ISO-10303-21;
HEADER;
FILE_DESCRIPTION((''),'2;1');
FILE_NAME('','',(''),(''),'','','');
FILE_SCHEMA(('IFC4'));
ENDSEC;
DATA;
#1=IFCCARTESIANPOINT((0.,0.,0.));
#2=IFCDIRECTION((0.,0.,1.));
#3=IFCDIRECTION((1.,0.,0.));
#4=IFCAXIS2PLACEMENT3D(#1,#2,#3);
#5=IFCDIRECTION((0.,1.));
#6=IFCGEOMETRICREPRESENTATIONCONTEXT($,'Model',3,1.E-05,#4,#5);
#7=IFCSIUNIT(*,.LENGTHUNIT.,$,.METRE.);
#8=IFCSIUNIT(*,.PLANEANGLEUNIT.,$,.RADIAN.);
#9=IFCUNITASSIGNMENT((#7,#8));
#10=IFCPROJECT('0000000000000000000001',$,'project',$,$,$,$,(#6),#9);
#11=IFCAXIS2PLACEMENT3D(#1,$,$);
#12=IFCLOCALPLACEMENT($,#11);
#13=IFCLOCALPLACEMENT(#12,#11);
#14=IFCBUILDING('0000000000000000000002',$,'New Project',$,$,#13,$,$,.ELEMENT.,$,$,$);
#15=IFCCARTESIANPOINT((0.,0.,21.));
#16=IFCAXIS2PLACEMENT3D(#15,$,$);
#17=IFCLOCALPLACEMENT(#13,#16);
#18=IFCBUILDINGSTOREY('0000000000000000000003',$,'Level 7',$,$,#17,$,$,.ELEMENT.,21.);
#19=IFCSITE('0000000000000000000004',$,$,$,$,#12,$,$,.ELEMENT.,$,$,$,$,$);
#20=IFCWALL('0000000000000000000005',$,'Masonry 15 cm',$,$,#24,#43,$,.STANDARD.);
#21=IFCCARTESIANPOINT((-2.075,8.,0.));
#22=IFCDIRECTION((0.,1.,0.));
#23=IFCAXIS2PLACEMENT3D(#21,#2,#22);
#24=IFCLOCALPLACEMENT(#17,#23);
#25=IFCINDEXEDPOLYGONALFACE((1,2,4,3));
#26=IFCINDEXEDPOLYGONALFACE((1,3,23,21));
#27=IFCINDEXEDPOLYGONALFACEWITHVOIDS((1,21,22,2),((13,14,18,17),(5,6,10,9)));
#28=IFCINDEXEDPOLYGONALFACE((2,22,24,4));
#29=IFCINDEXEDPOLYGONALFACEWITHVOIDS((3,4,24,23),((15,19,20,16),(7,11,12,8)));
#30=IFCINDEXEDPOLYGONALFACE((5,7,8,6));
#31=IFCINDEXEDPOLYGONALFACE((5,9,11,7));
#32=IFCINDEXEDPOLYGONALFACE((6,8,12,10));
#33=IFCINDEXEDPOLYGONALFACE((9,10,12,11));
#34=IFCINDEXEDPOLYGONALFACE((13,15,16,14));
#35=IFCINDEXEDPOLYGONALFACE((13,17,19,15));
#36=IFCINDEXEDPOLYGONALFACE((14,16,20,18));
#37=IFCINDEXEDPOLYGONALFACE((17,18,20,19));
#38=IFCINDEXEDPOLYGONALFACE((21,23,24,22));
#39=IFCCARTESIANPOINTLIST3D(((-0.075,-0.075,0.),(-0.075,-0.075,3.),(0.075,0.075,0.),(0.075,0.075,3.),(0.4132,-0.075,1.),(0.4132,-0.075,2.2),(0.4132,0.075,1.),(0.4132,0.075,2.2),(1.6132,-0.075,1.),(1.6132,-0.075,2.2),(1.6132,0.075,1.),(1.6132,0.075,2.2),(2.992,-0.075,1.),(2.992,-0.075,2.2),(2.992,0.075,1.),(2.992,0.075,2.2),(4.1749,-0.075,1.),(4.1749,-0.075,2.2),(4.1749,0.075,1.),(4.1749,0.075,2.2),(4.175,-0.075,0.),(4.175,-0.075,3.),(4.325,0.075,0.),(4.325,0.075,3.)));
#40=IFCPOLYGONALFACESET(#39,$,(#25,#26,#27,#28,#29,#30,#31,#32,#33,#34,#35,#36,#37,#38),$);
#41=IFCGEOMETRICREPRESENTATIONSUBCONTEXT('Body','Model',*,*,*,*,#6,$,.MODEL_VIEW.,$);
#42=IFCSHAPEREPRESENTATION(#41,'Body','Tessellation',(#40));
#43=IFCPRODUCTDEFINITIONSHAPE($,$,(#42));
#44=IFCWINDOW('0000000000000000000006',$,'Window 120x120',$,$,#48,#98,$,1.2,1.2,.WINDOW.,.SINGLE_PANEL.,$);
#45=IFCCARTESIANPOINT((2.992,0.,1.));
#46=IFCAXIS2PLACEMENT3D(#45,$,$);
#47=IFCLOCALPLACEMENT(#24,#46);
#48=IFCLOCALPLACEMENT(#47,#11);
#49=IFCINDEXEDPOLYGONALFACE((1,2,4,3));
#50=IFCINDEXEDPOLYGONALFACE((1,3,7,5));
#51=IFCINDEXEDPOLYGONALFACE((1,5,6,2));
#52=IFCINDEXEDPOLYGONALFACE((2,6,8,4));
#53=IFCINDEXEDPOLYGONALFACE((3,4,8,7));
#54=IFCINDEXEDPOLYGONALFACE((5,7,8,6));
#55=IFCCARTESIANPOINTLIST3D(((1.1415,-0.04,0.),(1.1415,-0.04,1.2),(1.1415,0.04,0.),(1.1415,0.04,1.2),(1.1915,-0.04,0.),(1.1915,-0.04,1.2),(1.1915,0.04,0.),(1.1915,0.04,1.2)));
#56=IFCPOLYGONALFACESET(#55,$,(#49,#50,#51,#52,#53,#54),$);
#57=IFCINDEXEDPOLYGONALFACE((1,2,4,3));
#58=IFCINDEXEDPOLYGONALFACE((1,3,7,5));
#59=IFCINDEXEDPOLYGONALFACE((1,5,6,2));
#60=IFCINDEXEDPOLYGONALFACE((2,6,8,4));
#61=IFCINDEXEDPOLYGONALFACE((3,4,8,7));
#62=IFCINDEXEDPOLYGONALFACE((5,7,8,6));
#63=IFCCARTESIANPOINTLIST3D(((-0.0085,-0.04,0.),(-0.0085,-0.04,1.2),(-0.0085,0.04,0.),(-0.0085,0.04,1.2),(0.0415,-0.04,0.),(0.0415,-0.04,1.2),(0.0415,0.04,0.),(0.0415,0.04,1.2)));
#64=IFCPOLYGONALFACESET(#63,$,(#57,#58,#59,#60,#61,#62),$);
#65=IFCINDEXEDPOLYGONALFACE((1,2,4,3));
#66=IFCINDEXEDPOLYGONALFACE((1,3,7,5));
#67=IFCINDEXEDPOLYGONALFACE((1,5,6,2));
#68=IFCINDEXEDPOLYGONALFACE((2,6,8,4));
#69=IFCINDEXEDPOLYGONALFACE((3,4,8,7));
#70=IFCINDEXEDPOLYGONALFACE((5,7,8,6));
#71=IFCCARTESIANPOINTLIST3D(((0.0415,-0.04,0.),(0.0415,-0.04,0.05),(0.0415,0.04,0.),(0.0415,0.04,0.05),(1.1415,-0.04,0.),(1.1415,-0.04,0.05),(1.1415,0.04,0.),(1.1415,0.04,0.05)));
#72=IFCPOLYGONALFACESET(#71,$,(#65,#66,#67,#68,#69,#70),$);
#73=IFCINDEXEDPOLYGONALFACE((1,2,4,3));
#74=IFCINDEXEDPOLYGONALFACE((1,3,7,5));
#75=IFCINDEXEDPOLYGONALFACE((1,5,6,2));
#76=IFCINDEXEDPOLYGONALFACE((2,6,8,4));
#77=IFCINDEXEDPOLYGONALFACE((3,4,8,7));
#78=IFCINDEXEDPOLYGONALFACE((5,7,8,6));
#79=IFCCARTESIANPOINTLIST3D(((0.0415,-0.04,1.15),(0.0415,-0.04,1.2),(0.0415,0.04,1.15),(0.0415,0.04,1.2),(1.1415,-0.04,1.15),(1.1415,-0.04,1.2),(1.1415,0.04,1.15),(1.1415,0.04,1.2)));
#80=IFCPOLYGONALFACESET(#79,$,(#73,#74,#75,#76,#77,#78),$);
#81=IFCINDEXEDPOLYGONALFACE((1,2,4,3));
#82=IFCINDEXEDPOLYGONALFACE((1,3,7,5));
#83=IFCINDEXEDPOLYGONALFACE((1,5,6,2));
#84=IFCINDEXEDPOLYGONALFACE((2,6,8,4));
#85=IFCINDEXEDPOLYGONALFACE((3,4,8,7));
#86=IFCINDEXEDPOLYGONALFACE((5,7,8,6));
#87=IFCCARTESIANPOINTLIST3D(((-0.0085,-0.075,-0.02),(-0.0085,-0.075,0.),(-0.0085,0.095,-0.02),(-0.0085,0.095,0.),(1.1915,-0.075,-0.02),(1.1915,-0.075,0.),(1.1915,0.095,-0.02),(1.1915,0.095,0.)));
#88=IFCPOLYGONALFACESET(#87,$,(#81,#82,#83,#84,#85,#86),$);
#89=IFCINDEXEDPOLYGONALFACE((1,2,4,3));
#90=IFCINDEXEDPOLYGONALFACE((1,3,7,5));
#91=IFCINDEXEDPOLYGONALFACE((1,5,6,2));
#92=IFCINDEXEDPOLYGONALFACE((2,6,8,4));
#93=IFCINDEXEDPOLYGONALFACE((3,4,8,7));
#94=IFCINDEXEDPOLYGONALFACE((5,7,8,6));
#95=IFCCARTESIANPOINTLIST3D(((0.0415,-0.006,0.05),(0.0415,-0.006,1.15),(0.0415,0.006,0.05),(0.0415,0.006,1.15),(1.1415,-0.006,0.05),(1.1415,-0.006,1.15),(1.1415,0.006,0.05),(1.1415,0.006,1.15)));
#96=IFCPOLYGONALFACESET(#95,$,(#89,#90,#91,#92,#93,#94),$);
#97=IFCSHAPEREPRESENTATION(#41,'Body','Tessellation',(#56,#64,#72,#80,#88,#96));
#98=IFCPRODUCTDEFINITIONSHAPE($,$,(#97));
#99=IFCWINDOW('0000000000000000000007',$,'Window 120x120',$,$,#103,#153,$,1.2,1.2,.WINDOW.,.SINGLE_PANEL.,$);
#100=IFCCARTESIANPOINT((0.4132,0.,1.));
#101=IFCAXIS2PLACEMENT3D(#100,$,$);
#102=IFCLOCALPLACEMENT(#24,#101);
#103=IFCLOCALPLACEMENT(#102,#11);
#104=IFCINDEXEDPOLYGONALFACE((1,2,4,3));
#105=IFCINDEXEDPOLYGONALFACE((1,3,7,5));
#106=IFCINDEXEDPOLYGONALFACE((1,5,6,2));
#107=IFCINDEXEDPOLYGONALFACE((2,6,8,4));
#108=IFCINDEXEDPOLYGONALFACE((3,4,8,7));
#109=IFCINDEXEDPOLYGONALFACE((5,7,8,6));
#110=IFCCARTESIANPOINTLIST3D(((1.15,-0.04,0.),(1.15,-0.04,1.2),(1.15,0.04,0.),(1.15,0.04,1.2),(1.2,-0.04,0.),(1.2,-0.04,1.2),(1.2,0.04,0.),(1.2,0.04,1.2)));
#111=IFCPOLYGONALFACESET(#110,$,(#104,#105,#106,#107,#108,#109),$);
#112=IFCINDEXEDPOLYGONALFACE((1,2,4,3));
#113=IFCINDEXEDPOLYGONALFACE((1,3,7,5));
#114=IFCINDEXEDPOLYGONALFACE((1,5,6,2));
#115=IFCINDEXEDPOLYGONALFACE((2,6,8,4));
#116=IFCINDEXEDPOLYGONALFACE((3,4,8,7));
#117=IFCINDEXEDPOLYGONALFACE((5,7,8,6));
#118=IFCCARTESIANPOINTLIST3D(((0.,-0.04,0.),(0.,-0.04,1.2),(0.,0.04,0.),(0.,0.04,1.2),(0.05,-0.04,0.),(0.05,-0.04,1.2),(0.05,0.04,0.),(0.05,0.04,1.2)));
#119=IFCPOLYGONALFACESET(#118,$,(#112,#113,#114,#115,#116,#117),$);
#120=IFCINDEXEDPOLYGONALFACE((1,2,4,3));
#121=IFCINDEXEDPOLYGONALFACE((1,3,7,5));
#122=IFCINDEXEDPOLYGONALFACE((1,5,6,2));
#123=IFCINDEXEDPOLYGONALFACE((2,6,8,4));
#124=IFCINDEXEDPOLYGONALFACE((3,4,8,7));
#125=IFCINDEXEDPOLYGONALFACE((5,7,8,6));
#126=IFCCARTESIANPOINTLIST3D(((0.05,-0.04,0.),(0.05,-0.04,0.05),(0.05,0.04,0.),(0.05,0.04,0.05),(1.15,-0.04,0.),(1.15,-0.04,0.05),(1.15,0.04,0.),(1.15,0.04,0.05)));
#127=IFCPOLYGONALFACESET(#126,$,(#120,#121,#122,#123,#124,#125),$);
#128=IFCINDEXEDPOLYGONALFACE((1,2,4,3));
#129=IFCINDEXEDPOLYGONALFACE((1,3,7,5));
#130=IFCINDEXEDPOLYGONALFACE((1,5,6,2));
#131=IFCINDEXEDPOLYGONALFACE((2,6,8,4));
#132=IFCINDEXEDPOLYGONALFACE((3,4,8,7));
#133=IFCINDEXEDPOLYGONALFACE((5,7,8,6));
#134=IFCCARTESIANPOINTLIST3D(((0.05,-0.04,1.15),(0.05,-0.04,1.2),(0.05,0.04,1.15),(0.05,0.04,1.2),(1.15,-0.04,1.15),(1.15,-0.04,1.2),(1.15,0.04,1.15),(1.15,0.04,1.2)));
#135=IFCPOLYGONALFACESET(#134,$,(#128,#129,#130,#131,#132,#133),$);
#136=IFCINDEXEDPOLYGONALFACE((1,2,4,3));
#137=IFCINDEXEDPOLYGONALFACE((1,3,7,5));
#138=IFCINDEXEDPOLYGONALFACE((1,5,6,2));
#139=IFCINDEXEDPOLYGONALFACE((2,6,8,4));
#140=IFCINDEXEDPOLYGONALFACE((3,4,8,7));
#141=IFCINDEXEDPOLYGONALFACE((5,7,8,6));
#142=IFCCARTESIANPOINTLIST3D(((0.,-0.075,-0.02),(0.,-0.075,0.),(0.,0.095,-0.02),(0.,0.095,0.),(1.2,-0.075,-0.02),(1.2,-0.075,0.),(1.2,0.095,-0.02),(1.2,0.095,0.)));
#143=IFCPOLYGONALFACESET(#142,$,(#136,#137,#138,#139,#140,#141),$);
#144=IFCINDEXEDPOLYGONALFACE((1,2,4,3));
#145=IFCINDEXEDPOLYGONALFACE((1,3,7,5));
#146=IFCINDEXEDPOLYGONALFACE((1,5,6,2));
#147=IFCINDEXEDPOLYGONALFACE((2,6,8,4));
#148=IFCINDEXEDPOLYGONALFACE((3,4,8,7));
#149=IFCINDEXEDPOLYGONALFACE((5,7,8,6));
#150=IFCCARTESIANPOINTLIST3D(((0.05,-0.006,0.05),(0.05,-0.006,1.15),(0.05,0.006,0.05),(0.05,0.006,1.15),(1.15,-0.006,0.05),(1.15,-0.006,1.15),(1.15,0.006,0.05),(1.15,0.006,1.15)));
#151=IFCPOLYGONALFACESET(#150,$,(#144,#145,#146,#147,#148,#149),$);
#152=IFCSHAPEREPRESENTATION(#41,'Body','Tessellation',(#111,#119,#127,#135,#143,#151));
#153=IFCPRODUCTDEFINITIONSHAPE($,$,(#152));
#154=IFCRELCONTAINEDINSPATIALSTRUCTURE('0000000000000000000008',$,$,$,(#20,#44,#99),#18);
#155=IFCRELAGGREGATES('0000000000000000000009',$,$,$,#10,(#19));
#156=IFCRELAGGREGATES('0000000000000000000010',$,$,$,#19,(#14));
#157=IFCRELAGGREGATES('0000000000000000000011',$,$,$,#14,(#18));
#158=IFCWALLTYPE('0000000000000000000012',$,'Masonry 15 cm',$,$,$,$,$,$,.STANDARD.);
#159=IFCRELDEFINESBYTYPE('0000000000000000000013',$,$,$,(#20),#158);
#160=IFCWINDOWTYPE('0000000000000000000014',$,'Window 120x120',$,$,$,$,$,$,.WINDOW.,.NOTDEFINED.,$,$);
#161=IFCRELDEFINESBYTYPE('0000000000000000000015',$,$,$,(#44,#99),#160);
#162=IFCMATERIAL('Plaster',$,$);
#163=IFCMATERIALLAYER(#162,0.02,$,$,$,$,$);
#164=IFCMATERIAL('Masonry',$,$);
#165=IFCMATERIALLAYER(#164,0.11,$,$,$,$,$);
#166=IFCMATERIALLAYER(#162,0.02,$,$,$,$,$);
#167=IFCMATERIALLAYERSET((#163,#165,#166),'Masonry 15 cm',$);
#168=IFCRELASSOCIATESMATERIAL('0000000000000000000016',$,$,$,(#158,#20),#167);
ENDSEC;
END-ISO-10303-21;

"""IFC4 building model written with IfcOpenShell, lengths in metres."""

from ifc_helpers import new_model, si_unit, direction, frame, frame_2d, origin, origin_with_axes, place, context, subcontext, project, spatial, polyline, rectangle, outline, extrude, material, layer, layer_set, layer_usage, type_object, element, fill, save


model = new_model("IFC4")

# Units and contexts
model_context = context("Model", 3, precision=1e-05, world=origin_with_axes(), true_north=direction((0.0, 1.0)))
body_context = subcontext(model_context, "Body", "Model", "MODEL_VIEW")
ifc_project = project(units=[si_unit("LENGTHUNIT", "METRE"), si_unit("PLANEANGLEUNIT", "RADIAN")], contexts=[model_context])

# Site, building, storey
site_placement = place(None, origin())
site = spatial("IfcSite", under=ifc_project, at=site_placement, CompositionType="ELEMENT")
building_placement = place(site_placement, origin())
building = spatial("IfcBuilding", under=site, at=building_placement, Name="New Project", CompositionType="ELEMENT")
storey_placement = place(building_placement, frame((0.0, 0.0, 21.0)))
storey = spatial("IfcBuildingStorey", under=building, at=storey_placement, Name="Level 7", CompositionType="ELEMENT", Elevation=21.0)

# Shared definitions
ifc_material_1 = material(Name="Plaster")
ifc_layer_1 = layer(ifc_material_1, 0.02)
ifc_material_2 = material(Name="Masonry")
ifc_layer_2 = layer(ifc_material_2, 0.11)
ifc_layer_3 = layer(ifc_material_1, 0.02)
ifc_layer_set_1 = layer_set([ifc_layer_1, ifc_layer_2, ifc_layer_3], Name="Masonry 15 cm")
ifc_layer_usage_1 = layer_usage(ifc_layer_set_1, "AXIS2", "NEGATIVE", 0.075)
wall_type = type_object("IfcWallType", Name="Masonry 15 cm", PredefinedType="STANDARD", material=ifc_layer_set_1)
window_type = type_object("IfcWindowType", Name="Window 120x120", PartitioningType="NOTDEFINED", PredefinedType="WINDOW")

# Wall, openings, windows
wall_1_placement = place(storey_placement, frame((-2.075, 8.0, 0.0), z_axis=(0.0, 0.0, 1.0), x_axis=(0.0, 1.0, 0.0)))
wall_1 = element("IfcWall", 1, at=wall_1_placement, inside=storey, type_object=wall_type, material=ifc_layer_usage_1, Name="Masonry 15 cm", PredefinedType="STANDARD", context=body_context, shape_type="SweptSolid", body=[
    extrude(outline(polyline([(-0.075, -0.075), (4.175, -0.075), (4.325, 0.075), (0.075, 0.075), (-0.075, -0.075)])), origin(), (0.0, 0.0, 1.0), 3.0),
])
opening_1_placement = place(wall_1_placement, frame((2.992, 0.0, 1.0)))
opening_1 = element("IfcOpeningElement", 2, at=opening_1_placement, cuts=wall_1, PredefinedType="OPENING", context=body_context, shape_type="SweptSolid", body=[
    extrude(rectangle(XDim=1.1829, YDim=0.25, at=frame_2d((0.5915, 0.0))), origin(), (0.0, 0.0, 1.0), 1.2),
])
opening_2_placement = place(wall_1_placement, frame((0.4132, 0.0, 1.0)))
opening_2 = element("IfcOpeningElement", 3, at=opening_2_placement, cuts=wall_1, PredefinedType="OPENING", context=body_context, shape_type="SweptSolid", body=[
    extrude(rectangle(XDim=1.2, YDim=0.25, at=frame_2d((0.6, 0.0))), origin(), (0.0, 0.0, 1.0), 1.2),
])
window_1_placement = place(opening_1_placement, origin())
window_1 = element("IfcWindow", 4, at=window_1_placement, inside=storey, type_object=window_type, Name="Window 120x120", OverallHeight=1.2, OverallWidth=1.2, PartitioningType="SINGLE_PANEL", PredefinedType="WINDOW", context=body_context, shape_type="SweptSolid", body=[
    extrude(outline(polyline([(1.1915, 0.04), (1.1415, 0.04), (1.1415, -0.04), (1.1915, -0.04), (1.1915, 0.04)])), origin(), (0.0, 0.0, 1.0), 1.2),
    extrude(outline(polyline([(0.0415, 0.04), (-0.0085, 0.04), (-0.0085, -0.04), (0.0415, -0.04), (0.0415, 0.04)])), origin(), (0.0, 0.0, 1.0), 1.2),
    extrude(outline(polyline([(1.1415, 0.04), (0.0415, 0.04), (0.0415, -0.04), (1.1415, -0.04), (1.1415, 0.04)])), origin(), (0.0, 0.0, 1.0), 0.05),
    extrude(outline(polyline([(1.1415, 0.04), (0.0415, 0.04), (0.0415, -0.04), (1.1415, -0.04), (1.1415, 0.04)])), frame((0.0, 0.0, 1.15)), (0.0, 0.0, 1.0), 0.05),
    extrude(outline(polyline([(1.1915, 0.095), (-0.0085, 0.095), (-0.0085, -0.075), (1.1915, -0.075), (1.1915, 0.095)])), frame((0.0, 0.0, -0.02)), (0.0, 0.0, 1.0), 0.02),
    extrude(outline(polyline([(1.1415, 0.006), (0.0415, 0.006), (0.0415, -0.006), (1.1415, -0.006), (1.1415, 0.006)])), frame((0.0, 0.0, 0.05)), (0.0, 0.0, 1.0), 1.1),
])
fill(opening_1, window_1)
window_2_placement = place(opening_2_placement, origin())
window_2 = element("IfcWindow", 5, at=window_2_placement, inside=storey, type_object=window_type, Name="Window 120x120", OverallHeight=1.2, OverallWidth=1.2, PartitioningType="SINGLE_PANEL", PredefinedType="WINDOW", context=body_context, shape_type="SweptSolid", body=[
    extrude(outline(polyline([(1.2, 0.04), (1.15, 0.04), (1.15, -0.04), (1.2, -0.04), (1.2, 0.04)])), origin(), (0.0, 0.0, 1.0), 1.2),
    extrude(outline(polyline([(0.05, 0.04), (0.0, 0.04), (0.0, -0.04), (0.05, -0.04), (0.05, 0.04)])), origin(), (0.0, 0.0, 1.0), 1.2),
    extrude(outline(polyline([(1.15, 0.04), (0.05, 0.04), (0.05, -0.04), (1.15, -0.04), (1.15, 0.04)])), origin(), (0.0, 0.0, 1.0), 0.05),
    extrude(outline(polyline([(1.15, 0.04), (0.05, 0.04), (0.05, -0.04), (1.15, -0.04), (1.15, 0.04)])), frame((0.0, 0.0, 1.15)), (0.0, 0.0, 1.0), 0.05),
    extrude(outline(polyline([(1.2, 0.095), (0.0, 0.095), (0.0, -0.075), (1.2, -0.075), (1.2, 0.095)])), frame((0.0, 0.0, -0.02)), (0.0, 0.0, 1.0), 0.02),
    extrude(outline(polyline([(1.15, 0.006), (0.05, 0.006), (0.05, -0.006), (1.15, -0.006), (1.15, 0.006)])), frame((0.0, 0.0, 0.05)), (0.0, 0.0, 1.0), 1.1),
])
fill(opening_2, window_2)

save(model, "model.ifc")
